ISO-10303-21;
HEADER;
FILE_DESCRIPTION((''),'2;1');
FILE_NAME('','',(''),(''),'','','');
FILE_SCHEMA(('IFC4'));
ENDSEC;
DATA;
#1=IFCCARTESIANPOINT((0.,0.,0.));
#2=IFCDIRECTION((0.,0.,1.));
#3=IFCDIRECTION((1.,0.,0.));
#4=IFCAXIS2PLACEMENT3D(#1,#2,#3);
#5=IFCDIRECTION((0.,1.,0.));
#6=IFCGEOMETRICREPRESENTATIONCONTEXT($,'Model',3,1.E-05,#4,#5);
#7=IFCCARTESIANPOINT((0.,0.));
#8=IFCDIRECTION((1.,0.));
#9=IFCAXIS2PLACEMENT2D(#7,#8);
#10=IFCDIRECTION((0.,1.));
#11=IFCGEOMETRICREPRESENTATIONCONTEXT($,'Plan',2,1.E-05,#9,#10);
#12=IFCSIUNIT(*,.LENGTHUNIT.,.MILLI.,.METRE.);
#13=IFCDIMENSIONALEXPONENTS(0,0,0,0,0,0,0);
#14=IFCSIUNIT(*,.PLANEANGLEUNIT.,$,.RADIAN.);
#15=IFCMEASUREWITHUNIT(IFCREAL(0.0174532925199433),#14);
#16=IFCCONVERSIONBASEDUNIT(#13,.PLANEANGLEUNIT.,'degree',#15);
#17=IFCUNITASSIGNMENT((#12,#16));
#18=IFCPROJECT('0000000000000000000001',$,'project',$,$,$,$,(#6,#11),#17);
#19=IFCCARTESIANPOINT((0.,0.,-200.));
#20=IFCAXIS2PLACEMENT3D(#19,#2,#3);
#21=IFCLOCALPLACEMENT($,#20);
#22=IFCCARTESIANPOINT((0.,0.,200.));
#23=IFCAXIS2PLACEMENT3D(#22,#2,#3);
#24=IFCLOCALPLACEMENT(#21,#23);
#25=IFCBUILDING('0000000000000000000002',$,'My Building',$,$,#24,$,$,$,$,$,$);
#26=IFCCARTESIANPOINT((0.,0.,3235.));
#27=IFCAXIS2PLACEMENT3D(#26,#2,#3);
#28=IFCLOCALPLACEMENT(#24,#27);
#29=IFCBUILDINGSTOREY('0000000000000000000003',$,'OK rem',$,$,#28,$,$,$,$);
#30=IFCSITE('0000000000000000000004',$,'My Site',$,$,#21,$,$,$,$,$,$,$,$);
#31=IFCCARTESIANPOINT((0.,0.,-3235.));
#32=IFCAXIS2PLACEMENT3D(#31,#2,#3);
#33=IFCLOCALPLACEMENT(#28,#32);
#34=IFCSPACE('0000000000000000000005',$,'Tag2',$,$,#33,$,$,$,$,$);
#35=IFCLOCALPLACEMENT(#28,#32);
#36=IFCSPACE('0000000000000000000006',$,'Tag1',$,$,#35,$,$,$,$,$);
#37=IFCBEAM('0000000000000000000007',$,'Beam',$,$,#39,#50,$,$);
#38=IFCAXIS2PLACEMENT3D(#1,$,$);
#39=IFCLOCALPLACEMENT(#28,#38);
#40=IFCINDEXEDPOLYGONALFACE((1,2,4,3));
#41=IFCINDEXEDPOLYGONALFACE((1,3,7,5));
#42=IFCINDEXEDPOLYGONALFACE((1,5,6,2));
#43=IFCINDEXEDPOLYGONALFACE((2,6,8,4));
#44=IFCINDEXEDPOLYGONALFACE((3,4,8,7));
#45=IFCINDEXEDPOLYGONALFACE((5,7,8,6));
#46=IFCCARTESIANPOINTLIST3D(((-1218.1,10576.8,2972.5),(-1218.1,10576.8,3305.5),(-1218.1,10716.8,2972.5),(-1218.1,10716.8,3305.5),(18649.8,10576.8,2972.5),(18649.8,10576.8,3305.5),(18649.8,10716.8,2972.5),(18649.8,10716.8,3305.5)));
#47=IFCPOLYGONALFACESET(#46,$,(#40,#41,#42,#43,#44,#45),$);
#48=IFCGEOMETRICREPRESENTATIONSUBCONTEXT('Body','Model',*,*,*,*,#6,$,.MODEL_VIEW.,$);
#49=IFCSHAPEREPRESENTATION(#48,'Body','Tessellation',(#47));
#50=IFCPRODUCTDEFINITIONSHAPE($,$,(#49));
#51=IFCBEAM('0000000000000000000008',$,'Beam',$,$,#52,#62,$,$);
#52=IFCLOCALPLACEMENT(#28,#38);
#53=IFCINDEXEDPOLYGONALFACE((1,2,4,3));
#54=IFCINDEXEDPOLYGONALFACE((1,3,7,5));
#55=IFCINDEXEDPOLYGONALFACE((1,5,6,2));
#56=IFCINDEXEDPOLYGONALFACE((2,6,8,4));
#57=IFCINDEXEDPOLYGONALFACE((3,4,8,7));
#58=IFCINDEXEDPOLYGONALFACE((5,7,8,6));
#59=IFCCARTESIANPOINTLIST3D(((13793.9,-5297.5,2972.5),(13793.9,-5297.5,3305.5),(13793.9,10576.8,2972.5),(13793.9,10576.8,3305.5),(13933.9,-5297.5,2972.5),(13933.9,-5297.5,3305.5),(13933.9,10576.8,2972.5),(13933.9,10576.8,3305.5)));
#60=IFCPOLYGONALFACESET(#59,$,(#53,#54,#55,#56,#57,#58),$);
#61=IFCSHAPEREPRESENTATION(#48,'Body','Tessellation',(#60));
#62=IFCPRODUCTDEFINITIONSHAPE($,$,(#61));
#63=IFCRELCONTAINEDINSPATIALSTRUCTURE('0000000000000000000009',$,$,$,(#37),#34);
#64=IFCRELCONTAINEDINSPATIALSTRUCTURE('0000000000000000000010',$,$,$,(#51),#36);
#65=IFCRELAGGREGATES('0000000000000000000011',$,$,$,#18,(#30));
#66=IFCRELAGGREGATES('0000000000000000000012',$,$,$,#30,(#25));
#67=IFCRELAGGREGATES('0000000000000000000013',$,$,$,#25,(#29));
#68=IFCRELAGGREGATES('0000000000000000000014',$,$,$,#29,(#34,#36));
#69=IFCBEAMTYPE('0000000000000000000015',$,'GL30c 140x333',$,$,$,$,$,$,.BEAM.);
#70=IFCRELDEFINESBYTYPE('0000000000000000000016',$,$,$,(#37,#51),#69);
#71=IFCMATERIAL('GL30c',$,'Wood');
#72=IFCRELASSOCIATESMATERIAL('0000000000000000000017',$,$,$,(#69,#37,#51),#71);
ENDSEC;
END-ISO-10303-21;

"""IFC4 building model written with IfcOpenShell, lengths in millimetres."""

from ifc_helpers import new_model, entity, si_unit, converted_unit, direction, frame, origin_with_axes, origin_2d_with_axis, place, context, subcontext, project, spatial, rectangle, extrude, material, material_profile, profile_set, profile_usage, type_object, element, save


model = new_model("IFC4")

# Units and contexts
model_context = context("Model", 3, precision=1e-05, world=origin_with_axes(), true_north=direction((0.0, 1.0, 0.0)))
plan_context = context("Plan", 2, precision=1e-05, world=origin_2d_with_axis(), true_north=direction((0.0, 1.0)))
body_context = subcontext(model_context, "Body", "Model", "MODEL_VIEW")
ifc_project = project(units=[si_unit("LENGTHUNIT", "METRE", prefix="MILLI"), converted_unit("PLANEANGLEUNIT", "degree", entity("IfcReal", 0.0174532925199433), si_unit("PLANEANGLEUNIT", "RADIAN"), dimensions=[0, 0, 0, 0, 0, 0, 0])], contexts=[model_context, plan_context])

# Site, building, storey, space
site_placement = place(None, frame((0.0, 0.0, -200.0), z_axis=(0.0, 0.0, 1.0), x_axis=(1.0, 0.0, 0.0)))
site = spatial("IfcSite", under=ifc_project, at=site_placement, Name="My Site")
building_placement = place(site_placement, frame((0.0, 0.0, 200.0), z_axis=(0.0, 0.0, 1.0), x_axis=(1.0, 0.0, 0.0)))
building = spatial("IfcBuilding", under=site, at=building_placement, Name="My Building")
storey_placement = place(building_placement, frame((0.0, 0.0, 3235.0), z_axis=(0.0, 0.0, 1.0), x_axis=(1.0, 0.0, 0.0)))
storey = spatial("IfcBuildingStorey", under=building, at=storey_placement, Name="OK rem")
space_1_placement = place(storey_placement, frame((0.0, 0.0, -3235.0), z_axis=(0.0, 0.0, 1.0), x_axis=(1.0, 0.0, 0.0)))
space_1 = spatial("IfcSpace", under=storey, at=space_1_placement, Name="Tag2")

# Beam
ifc_material_1 = material(Name="GL30c", Category="Wood")
ifc_material_profile_1 = material_profile(ifc_material_1, rectangle(XDim=140.0, YDim=333.0))
ifc_profile_set_1 = profile_set([ifc_material_profile_1], Name="woodStructural")
ifc_profile_usage_1 = profile_usage(ifc_profile_set_1)
beam_type_1 = type_object("IfcBeamType", Name="GL30c 140x333", PredefinedType="BEAM", material=ifc_profile_set_1)
beam_1_placement = place(space_1_placement, frame((-1218.1, 10646.8, 6374.0), z_axis=(1.0, 0.0, 0.0), x_axis=(0.0, 1.0, 0.0)))
element("IfcBeam", 1, at=beam_1_placement, inside=space_1, type_object=beam_type_1, material=ifc_profile_usage_1, Name="Beam", context=body_context, shape_type="SweptSolid", body=[
    extrude(rectangle(XDim=140.0, YDim=333.0), origin_with_axes(), (0.0, 0.0, 1.0), 19867.9),
])

# Shared definitions
space_2_placement = place(storey_placement, frame((0.0, 0.0, -3235.0), z_axis=(0.0, 0.0, 1.0), x_axis=(1.0, 0.0, 0.0)))
space_2 = spatial("IfcSpace", under=storey, at=space_2_placement, Name="Tag1")

# Beam
ifc_profile_usage_2 = profile_usage(ifc_profile_set_1)
beam_2_placement = place(space_2_placement, frame((13863.9, -5297.5, 6374.0), z_axis=(0.0, 1.0, 0.0), x_axis=(-1.0, 0.0, 0.0)))
element("IfcBeam", 2, at=beam_2_placement, inside=space_2, type_object=beam_type_1, material=ifc_profile_usage_2, Name="Beam", context=body_context, shape_type="SweptSolid", body=[
    extrude(rectangle(XDim=140.0, YDim=333.0), origin_with_axes(), (0.0, 0.0, 1.0), 15874.3),
])

save(model, "model.ifc")
